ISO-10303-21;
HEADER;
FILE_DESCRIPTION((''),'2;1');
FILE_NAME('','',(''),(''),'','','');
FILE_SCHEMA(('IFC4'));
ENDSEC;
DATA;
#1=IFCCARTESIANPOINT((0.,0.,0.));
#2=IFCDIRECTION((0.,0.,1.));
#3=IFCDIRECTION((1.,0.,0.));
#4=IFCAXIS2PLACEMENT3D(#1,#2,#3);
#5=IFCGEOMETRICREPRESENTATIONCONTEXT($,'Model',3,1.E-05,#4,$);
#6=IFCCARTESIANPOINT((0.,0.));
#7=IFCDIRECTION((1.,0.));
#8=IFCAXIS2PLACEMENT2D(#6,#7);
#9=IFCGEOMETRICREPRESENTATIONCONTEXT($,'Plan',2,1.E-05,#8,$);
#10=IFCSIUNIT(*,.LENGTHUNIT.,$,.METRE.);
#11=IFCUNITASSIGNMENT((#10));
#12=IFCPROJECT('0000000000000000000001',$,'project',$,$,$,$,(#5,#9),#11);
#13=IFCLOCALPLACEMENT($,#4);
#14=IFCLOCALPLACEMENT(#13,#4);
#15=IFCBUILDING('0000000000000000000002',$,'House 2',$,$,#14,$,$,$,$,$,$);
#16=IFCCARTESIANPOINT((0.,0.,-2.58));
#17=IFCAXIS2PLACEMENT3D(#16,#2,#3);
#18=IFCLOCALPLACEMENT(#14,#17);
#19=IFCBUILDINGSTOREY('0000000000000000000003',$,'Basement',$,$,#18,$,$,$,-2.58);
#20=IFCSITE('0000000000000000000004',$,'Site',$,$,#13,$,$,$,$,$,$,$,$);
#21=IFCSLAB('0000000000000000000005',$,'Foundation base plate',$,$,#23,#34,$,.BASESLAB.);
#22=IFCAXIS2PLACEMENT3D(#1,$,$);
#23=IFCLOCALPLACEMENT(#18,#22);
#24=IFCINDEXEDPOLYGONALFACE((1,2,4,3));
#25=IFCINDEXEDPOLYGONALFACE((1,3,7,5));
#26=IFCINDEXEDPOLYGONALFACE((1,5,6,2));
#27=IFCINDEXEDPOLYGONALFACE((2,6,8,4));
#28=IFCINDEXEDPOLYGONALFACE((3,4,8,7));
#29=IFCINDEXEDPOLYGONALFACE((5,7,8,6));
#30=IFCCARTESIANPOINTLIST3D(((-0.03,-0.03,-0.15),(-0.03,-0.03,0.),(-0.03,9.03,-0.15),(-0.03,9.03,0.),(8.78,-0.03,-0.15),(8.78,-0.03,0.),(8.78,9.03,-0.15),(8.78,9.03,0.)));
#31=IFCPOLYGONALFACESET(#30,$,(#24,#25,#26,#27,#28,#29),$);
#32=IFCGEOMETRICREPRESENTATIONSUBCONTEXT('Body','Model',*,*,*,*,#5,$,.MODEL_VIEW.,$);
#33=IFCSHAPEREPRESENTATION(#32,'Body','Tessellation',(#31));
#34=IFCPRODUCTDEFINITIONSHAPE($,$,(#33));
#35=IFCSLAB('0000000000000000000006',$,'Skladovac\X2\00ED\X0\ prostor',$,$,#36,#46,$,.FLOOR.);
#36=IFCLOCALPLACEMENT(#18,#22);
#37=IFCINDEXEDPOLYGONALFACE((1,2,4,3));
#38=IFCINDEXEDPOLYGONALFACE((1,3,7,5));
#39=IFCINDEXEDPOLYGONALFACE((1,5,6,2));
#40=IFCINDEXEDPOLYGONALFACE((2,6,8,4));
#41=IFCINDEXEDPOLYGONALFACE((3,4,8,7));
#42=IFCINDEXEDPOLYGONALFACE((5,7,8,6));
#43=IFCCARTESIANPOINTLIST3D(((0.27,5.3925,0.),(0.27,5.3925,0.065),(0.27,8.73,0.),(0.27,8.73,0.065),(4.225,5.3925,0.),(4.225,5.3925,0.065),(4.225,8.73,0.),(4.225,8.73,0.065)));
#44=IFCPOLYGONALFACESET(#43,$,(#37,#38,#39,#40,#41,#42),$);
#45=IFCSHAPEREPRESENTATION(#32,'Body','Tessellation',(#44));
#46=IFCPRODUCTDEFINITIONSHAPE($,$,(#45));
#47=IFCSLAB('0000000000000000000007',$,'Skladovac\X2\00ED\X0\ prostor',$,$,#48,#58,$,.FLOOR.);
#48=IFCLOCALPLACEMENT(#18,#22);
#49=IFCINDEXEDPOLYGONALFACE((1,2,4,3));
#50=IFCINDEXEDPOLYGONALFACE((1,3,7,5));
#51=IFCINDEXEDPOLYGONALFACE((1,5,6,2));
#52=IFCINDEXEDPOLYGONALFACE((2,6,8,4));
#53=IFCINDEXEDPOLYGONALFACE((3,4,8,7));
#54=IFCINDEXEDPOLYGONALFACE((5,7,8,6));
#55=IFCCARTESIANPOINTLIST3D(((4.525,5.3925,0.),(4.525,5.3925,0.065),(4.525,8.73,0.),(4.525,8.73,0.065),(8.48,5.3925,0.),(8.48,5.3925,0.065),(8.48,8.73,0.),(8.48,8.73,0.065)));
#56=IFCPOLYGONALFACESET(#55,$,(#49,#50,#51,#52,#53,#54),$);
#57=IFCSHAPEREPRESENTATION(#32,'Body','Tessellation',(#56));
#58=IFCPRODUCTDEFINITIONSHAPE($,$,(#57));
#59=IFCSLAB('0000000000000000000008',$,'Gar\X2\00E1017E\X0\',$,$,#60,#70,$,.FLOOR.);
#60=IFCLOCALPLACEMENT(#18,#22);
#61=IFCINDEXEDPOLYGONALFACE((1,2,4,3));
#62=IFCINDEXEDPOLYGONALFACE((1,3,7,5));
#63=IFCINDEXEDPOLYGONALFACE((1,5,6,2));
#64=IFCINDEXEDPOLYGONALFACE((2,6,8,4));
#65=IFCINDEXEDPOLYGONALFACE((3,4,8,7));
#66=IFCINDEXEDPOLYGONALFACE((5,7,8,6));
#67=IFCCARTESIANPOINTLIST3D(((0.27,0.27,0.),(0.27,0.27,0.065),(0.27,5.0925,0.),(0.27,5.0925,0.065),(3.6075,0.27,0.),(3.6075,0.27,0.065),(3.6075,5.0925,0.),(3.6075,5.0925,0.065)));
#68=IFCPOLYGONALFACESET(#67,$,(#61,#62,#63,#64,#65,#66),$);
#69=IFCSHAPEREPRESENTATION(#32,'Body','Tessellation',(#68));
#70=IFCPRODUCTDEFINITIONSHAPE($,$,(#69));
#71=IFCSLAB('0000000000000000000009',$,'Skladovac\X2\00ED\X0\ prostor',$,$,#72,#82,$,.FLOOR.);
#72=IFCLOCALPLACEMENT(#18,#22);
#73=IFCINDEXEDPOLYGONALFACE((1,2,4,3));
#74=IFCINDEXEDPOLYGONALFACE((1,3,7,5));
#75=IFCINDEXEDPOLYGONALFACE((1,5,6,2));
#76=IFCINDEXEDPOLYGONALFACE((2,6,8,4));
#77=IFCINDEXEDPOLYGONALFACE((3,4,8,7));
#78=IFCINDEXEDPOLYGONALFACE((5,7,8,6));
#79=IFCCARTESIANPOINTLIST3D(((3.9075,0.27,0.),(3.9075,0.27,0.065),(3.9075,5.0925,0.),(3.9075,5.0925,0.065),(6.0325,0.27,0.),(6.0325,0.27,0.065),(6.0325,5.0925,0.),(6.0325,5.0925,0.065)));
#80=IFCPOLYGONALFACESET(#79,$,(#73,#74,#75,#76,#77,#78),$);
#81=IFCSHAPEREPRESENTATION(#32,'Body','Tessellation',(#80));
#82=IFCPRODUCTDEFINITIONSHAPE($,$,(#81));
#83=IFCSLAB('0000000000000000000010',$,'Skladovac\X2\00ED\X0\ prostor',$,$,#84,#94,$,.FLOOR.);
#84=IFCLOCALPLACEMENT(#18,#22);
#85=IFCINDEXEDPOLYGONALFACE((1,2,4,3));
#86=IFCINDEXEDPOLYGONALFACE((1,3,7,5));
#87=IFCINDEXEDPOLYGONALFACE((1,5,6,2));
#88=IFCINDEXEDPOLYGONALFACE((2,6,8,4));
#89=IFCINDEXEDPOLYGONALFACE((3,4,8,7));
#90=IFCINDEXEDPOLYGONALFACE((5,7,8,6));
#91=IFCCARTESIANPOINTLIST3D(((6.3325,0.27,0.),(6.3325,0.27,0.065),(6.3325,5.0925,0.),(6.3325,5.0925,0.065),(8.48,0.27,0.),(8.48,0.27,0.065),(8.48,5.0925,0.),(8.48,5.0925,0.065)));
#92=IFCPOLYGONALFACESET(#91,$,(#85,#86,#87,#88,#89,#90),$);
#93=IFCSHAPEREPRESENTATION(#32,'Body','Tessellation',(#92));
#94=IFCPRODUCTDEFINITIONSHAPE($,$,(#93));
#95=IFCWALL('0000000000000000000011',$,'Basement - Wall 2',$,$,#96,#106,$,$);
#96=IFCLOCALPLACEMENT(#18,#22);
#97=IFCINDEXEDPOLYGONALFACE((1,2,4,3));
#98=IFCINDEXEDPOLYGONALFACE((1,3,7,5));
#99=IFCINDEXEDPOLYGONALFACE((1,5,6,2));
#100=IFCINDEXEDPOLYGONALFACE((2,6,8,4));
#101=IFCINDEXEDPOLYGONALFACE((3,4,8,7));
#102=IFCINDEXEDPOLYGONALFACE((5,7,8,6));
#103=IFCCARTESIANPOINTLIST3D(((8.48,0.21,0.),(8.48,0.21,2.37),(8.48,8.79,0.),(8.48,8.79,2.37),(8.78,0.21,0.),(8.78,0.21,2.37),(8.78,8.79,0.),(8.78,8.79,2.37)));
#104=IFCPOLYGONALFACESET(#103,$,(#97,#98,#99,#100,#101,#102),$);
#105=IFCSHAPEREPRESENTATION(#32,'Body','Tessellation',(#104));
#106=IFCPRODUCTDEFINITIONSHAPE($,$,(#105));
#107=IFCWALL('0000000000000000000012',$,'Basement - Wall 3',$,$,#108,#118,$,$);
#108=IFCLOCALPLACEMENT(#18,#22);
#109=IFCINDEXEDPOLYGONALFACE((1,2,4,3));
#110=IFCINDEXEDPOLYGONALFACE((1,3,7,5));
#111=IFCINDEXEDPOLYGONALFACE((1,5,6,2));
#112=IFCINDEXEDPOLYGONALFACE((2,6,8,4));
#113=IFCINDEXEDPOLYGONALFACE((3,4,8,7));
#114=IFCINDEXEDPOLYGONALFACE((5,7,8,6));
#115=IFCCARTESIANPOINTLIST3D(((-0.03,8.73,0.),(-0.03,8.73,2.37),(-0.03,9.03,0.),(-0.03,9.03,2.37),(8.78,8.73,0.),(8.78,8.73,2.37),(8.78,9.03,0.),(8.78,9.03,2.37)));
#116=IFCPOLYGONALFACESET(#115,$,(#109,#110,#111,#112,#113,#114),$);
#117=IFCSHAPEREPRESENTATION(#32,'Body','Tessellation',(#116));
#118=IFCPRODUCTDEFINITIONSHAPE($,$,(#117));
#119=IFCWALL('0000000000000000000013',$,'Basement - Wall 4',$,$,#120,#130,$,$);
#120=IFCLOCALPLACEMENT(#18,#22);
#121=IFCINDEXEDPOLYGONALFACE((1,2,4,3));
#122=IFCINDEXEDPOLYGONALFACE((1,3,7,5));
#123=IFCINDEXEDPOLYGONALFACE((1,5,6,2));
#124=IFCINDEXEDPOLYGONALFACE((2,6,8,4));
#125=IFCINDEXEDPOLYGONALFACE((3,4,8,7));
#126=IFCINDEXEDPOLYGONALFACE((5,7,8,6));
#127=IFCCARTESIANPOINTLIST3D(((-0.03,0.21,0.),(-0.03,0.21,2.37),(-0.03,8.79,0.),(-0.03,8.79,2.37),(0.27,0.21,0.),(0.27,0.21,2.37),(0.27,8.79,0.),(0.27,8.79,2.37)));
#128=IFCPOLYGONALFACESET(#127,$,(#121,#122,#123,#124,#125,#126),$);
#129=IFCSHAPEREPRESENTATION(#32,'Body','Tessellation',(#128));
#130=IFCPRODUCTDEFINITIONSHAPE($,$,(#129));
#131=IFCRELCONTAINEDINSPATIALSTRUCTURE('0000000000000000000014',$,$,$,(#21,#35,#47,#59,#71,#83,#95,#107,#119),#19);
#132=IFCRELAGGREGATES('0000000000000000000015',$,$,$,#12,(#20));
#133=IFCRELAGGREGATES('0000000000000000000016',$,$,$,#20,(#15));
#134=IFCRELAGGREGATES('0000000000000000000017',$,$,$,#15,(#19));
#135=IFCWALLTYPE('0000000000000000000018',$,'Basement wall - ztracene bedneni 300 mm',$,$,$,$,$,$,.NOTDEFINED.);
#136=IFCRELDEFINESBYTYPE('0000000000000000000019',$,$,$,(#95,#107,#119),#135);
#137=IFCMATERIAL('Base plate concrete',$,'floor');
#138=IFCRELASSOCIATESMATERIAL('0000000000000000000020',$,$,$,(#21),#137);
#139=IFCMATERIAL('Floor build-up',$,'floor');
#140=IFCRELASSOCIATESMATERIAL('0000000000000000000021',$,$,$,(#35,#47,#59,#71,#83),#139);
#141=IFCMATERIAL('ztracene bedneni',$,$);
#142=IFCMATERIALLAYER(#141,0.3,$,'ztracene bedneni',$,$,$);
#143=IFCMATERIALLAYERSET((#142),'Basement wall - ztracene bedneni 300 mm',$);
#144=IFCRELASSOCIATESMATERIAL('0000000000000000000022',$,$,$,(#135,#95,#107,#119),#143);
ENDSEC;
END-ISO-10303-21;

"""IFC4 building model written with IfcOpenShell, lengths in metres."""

from ifc_helpers import new_model, si_unit, frame, origin_with_axes, origin_2d_with_axis, place, context, subcontext, project, spatial, indexed_curve, outline, extrude, material, layer, layer_set, layer_usage, type_object, element, save


model = new_model("IFC4")

# Units and contexts
model_context = context("Model", 3, precision=1e-05, world=origin_with_axes())
plan_context = context("Plan", 2, precision=1e-05, world=origin_2d_with_axis())
body_context_1 = subcontext(model_context, "Body", "Model", "MODEL_VIEW")
ifc_project = project(units=[si_unit("LENGTHUNIT", "METRE")], contexts=[model_context, plan_context])

# Site, building, storey
site_placement = place(None, origin_with_axes())
site = spatial("IfcSite", under=ifc_project, at=site_placement, Name="Site")
building_placement = place(site_placement, origin_with_axes())
building = spatial("IfcBuilding", under=site, at=building_placement, Name="House 2")
storey_placement = place(building_placement, frame((0.0, 0.0, -2.58), z_axis=(0.0, 0.0, 1.0), x_axis=(1.0, 0.0, 0.0)))
storey = spatial("IfcBuildingStorey", under=building, at=storey_placement, Name="Basement", Elevation=-2.58)

# Slabs
ifc_material_1 = material(Name="Base plate concrete", Category="floor")
slab_1_placement = place(storey_placement, frame((0.0, 0.0, -0.15), z_axis=(0.0, 0.0, 1.0), x_axis=(1.0, 0.0, 0.0)))
element("IfcSlab", 1, at=slab_1_placement, inside=storey, material=ifc_material_1, Name="Foundation base plate", PredefinedType="BASESLAB", context=body_context_1, shape_type="SweptSolid", body=[
    extrude(outline(indexed_curve([(-0.03, -0.03), (8.78, -0.03), (8.78, 9.03), (-0.03, 9.03)])), None, (0.0, 0.0, 1.0), 0.15),
])
ifc_material_2 = material(Name="Floor build-up", Category="floor")
slab_2_placement = place(storey_placement, origin_with_axes())
element("IfcSlab", 2, at=slab_2_placement, inside=storey, material=ifc_material_2, Name="Skladovací prostor", PredefinedType="FLOOR", context=body_context_1, shape_type="SweptSolid", body=[
    extrude(outline(indexed_curve([(0.27, 8.73), (4.225, 8.73), (4.225, 5.3925), (0.27, 5.3925)])), None, (0.0, 0.0, 1.0), 0.065),
])
slab_3_placement = place(storey_placement, origin_with_axes())
element("IfcSlab", 3, at=slab_3_placement, inside=storey, material=ifc_material_2, Name="Skladovací prostor", PredefinedType="FLOOR", context=body_context_1, shape_type="SweptSolid", body=[
    extrude(outline(indexed_curve([(8.48, 5.3925), (4.525, 5.3925), (4.525, 8.73), (8.48, 8.73)])), None, (0.0, 0.0, 1.0), 0.065),
])
slab_4_placement = place(storey_placement, origin_with_axes())
element("IfcSlab", 4, at=slab_4_placement, inside=storey, material=ifc_material_2, Name="Garáž", PredefinedType="FLOOR", context=body_context_1, shape_type="SweptSolid", body=[
    extrude(outline(indexed_curve([(0.27, 5.0925), (3.6075, 5.0925), (3.6075, 0.27), (0.27, 0.27)])), None, (0.0, 0.0, 1.0), 0.065),
])
slab_5_placement = place(storey_placement, origin_with_axes())
element("IfcSlab", 5, at=slab_5_placement, inside=storey, material=ifc_material_2, Name="Skladovací prostor", PredefinedType="FLOOR", context=body_context_1, shape_type="SweptSolid", body=[
    extrude(outline(indexed_curve([(3.9075, 5.0925), (6.0325, 5.0925), (6.0325, 0.27), (3.9075, 0.27)])), None, (0.0, 0.0, 1.0), 0.065),
])
slab_6_placement = place(storey_placement, origin_with_axes())
element("IfcSlab", 6, at=slab_6_placement, inside=storey, material=ifc_material_2, Name="Skladovací prostor", PredefinedType="FLOOR", context=body_context_1, shape_type="SweptSolid", body=[
    extrude(outline(indexed_curve([(6.3325, 5.0925), (8.48, 5.0925), (8.48, 0.27), (6.3325, 0.27)])), None, (0.0, 0.0, 1.0), 0.065),
])

# Shared definitions
ifc_material_3 = material(Name="ztracene bedneni")
ifc_layer = layer(ifc_material_3, 0.3, Name="ztracene bedneni")
ifc_layer_set = layer_set([ifc_layer], Name="Basement wall - ztracene bedneni 300 mm")
wall_type = type_object("IfcWallType", Name="Basement wall - ztracene bedneni 300 mm", PredefinedType="NOTDEFINED", material=ifc_layer_set)

# Walls
ifc_layer_usage_1 = layer_usage(ifc_layer_set, "AXIS2", "NEGATIVE", 0.15)
wall_1_placement = place(storey_placement, frame((8.63, 0.21, 0.0), z_axis=(0.0, 0.0, 1.0), x_axis=(0.0, 1.0, 0.0)))
element("IfcWall", 7, at=wall_1_placement, inside=storey, type_object=wall_type, material=ifc_layer_usage_1, Name="Basement - Wall 2", context=body_context_1, shape_type="SweptSolid", body=[
    extrude(outline(indexed_curve([(0.0, 0.0), (0.0, 0.3), (8.58, 0.3), (8.58, 0.0), (0.0, 0.0)], self_intersect=False)), frame((0.0, -0.15, 0.0), z_axis=(0.0, 0.0, 1.0), x_axis=(1.0, 0.0, 0.0)), (0.0, 0.0, 1.0), 2.37),
])
ifc_layer_usage_2 = layer_usage(ifc_layer_set, "AXIS2", "NEGATIVE", 0.15)
wall_2_placement = place(storey_placement, frame((8.78, 8.88, 0.0), z_axis=(0.0, 0.0, 1.0), x_axis=(-1.0, 0.0, 0.0)))
element("IfcWall", 8, at=wall_2_placement, inside=storey, type_object=wall_type, material=ifc_layer_usage_2, Name="Basement - Wall 3", context=body_context_1, shape_type="SweptSolid", body=[
    extrude(outline(indexed_curve([(0.0, 0.0), (0.0, 0.3), (8.81, 0.3), (8.81, 0.0), (0.0, 0.0)], self_intersect=False)), frame((0.0, -0.15, 0.0), z_axis=(0.0, 0.0, 1.0), x_axis=(1.0, 0.0, 0.0)), (0.0, 0.0, 1.0), 2.37),
])
ifc_layer_usage_3 = layer_usage(ifc_layer_set, "AXIS2", "NEGATIVE", 0.15)
wall_3_placement = place(storey_placement, frame((0.12, 8.79, 0.0), z_axis=(0.0, 0.0, 1.0), x_axis=(0.0, -1.0, 0.0)))
element("IfcWall", 9, at=wall_3_placement, inside=storey, type_object=wall_type, material=ifc_layer_usage_3, Name="Basement - Wall 4", context=body_context_1, shape_type="SweptSolid", body=[
    extrude(outline(indexed_curve([(0.0, 0.0), (0.0, 0.3), (8.58, 0.3), (8.58, 0.0), (0.0, 0.0)], self_intersect=False)), frame((0.0, -0.15, 0.0), z_axis=(0.0, 0.0, 1.0), x_axis=(1.0, 0.0, 0.0)), (0.0, 0.0, 1.0), 2.37),
])

save(model, "model.ifc")
